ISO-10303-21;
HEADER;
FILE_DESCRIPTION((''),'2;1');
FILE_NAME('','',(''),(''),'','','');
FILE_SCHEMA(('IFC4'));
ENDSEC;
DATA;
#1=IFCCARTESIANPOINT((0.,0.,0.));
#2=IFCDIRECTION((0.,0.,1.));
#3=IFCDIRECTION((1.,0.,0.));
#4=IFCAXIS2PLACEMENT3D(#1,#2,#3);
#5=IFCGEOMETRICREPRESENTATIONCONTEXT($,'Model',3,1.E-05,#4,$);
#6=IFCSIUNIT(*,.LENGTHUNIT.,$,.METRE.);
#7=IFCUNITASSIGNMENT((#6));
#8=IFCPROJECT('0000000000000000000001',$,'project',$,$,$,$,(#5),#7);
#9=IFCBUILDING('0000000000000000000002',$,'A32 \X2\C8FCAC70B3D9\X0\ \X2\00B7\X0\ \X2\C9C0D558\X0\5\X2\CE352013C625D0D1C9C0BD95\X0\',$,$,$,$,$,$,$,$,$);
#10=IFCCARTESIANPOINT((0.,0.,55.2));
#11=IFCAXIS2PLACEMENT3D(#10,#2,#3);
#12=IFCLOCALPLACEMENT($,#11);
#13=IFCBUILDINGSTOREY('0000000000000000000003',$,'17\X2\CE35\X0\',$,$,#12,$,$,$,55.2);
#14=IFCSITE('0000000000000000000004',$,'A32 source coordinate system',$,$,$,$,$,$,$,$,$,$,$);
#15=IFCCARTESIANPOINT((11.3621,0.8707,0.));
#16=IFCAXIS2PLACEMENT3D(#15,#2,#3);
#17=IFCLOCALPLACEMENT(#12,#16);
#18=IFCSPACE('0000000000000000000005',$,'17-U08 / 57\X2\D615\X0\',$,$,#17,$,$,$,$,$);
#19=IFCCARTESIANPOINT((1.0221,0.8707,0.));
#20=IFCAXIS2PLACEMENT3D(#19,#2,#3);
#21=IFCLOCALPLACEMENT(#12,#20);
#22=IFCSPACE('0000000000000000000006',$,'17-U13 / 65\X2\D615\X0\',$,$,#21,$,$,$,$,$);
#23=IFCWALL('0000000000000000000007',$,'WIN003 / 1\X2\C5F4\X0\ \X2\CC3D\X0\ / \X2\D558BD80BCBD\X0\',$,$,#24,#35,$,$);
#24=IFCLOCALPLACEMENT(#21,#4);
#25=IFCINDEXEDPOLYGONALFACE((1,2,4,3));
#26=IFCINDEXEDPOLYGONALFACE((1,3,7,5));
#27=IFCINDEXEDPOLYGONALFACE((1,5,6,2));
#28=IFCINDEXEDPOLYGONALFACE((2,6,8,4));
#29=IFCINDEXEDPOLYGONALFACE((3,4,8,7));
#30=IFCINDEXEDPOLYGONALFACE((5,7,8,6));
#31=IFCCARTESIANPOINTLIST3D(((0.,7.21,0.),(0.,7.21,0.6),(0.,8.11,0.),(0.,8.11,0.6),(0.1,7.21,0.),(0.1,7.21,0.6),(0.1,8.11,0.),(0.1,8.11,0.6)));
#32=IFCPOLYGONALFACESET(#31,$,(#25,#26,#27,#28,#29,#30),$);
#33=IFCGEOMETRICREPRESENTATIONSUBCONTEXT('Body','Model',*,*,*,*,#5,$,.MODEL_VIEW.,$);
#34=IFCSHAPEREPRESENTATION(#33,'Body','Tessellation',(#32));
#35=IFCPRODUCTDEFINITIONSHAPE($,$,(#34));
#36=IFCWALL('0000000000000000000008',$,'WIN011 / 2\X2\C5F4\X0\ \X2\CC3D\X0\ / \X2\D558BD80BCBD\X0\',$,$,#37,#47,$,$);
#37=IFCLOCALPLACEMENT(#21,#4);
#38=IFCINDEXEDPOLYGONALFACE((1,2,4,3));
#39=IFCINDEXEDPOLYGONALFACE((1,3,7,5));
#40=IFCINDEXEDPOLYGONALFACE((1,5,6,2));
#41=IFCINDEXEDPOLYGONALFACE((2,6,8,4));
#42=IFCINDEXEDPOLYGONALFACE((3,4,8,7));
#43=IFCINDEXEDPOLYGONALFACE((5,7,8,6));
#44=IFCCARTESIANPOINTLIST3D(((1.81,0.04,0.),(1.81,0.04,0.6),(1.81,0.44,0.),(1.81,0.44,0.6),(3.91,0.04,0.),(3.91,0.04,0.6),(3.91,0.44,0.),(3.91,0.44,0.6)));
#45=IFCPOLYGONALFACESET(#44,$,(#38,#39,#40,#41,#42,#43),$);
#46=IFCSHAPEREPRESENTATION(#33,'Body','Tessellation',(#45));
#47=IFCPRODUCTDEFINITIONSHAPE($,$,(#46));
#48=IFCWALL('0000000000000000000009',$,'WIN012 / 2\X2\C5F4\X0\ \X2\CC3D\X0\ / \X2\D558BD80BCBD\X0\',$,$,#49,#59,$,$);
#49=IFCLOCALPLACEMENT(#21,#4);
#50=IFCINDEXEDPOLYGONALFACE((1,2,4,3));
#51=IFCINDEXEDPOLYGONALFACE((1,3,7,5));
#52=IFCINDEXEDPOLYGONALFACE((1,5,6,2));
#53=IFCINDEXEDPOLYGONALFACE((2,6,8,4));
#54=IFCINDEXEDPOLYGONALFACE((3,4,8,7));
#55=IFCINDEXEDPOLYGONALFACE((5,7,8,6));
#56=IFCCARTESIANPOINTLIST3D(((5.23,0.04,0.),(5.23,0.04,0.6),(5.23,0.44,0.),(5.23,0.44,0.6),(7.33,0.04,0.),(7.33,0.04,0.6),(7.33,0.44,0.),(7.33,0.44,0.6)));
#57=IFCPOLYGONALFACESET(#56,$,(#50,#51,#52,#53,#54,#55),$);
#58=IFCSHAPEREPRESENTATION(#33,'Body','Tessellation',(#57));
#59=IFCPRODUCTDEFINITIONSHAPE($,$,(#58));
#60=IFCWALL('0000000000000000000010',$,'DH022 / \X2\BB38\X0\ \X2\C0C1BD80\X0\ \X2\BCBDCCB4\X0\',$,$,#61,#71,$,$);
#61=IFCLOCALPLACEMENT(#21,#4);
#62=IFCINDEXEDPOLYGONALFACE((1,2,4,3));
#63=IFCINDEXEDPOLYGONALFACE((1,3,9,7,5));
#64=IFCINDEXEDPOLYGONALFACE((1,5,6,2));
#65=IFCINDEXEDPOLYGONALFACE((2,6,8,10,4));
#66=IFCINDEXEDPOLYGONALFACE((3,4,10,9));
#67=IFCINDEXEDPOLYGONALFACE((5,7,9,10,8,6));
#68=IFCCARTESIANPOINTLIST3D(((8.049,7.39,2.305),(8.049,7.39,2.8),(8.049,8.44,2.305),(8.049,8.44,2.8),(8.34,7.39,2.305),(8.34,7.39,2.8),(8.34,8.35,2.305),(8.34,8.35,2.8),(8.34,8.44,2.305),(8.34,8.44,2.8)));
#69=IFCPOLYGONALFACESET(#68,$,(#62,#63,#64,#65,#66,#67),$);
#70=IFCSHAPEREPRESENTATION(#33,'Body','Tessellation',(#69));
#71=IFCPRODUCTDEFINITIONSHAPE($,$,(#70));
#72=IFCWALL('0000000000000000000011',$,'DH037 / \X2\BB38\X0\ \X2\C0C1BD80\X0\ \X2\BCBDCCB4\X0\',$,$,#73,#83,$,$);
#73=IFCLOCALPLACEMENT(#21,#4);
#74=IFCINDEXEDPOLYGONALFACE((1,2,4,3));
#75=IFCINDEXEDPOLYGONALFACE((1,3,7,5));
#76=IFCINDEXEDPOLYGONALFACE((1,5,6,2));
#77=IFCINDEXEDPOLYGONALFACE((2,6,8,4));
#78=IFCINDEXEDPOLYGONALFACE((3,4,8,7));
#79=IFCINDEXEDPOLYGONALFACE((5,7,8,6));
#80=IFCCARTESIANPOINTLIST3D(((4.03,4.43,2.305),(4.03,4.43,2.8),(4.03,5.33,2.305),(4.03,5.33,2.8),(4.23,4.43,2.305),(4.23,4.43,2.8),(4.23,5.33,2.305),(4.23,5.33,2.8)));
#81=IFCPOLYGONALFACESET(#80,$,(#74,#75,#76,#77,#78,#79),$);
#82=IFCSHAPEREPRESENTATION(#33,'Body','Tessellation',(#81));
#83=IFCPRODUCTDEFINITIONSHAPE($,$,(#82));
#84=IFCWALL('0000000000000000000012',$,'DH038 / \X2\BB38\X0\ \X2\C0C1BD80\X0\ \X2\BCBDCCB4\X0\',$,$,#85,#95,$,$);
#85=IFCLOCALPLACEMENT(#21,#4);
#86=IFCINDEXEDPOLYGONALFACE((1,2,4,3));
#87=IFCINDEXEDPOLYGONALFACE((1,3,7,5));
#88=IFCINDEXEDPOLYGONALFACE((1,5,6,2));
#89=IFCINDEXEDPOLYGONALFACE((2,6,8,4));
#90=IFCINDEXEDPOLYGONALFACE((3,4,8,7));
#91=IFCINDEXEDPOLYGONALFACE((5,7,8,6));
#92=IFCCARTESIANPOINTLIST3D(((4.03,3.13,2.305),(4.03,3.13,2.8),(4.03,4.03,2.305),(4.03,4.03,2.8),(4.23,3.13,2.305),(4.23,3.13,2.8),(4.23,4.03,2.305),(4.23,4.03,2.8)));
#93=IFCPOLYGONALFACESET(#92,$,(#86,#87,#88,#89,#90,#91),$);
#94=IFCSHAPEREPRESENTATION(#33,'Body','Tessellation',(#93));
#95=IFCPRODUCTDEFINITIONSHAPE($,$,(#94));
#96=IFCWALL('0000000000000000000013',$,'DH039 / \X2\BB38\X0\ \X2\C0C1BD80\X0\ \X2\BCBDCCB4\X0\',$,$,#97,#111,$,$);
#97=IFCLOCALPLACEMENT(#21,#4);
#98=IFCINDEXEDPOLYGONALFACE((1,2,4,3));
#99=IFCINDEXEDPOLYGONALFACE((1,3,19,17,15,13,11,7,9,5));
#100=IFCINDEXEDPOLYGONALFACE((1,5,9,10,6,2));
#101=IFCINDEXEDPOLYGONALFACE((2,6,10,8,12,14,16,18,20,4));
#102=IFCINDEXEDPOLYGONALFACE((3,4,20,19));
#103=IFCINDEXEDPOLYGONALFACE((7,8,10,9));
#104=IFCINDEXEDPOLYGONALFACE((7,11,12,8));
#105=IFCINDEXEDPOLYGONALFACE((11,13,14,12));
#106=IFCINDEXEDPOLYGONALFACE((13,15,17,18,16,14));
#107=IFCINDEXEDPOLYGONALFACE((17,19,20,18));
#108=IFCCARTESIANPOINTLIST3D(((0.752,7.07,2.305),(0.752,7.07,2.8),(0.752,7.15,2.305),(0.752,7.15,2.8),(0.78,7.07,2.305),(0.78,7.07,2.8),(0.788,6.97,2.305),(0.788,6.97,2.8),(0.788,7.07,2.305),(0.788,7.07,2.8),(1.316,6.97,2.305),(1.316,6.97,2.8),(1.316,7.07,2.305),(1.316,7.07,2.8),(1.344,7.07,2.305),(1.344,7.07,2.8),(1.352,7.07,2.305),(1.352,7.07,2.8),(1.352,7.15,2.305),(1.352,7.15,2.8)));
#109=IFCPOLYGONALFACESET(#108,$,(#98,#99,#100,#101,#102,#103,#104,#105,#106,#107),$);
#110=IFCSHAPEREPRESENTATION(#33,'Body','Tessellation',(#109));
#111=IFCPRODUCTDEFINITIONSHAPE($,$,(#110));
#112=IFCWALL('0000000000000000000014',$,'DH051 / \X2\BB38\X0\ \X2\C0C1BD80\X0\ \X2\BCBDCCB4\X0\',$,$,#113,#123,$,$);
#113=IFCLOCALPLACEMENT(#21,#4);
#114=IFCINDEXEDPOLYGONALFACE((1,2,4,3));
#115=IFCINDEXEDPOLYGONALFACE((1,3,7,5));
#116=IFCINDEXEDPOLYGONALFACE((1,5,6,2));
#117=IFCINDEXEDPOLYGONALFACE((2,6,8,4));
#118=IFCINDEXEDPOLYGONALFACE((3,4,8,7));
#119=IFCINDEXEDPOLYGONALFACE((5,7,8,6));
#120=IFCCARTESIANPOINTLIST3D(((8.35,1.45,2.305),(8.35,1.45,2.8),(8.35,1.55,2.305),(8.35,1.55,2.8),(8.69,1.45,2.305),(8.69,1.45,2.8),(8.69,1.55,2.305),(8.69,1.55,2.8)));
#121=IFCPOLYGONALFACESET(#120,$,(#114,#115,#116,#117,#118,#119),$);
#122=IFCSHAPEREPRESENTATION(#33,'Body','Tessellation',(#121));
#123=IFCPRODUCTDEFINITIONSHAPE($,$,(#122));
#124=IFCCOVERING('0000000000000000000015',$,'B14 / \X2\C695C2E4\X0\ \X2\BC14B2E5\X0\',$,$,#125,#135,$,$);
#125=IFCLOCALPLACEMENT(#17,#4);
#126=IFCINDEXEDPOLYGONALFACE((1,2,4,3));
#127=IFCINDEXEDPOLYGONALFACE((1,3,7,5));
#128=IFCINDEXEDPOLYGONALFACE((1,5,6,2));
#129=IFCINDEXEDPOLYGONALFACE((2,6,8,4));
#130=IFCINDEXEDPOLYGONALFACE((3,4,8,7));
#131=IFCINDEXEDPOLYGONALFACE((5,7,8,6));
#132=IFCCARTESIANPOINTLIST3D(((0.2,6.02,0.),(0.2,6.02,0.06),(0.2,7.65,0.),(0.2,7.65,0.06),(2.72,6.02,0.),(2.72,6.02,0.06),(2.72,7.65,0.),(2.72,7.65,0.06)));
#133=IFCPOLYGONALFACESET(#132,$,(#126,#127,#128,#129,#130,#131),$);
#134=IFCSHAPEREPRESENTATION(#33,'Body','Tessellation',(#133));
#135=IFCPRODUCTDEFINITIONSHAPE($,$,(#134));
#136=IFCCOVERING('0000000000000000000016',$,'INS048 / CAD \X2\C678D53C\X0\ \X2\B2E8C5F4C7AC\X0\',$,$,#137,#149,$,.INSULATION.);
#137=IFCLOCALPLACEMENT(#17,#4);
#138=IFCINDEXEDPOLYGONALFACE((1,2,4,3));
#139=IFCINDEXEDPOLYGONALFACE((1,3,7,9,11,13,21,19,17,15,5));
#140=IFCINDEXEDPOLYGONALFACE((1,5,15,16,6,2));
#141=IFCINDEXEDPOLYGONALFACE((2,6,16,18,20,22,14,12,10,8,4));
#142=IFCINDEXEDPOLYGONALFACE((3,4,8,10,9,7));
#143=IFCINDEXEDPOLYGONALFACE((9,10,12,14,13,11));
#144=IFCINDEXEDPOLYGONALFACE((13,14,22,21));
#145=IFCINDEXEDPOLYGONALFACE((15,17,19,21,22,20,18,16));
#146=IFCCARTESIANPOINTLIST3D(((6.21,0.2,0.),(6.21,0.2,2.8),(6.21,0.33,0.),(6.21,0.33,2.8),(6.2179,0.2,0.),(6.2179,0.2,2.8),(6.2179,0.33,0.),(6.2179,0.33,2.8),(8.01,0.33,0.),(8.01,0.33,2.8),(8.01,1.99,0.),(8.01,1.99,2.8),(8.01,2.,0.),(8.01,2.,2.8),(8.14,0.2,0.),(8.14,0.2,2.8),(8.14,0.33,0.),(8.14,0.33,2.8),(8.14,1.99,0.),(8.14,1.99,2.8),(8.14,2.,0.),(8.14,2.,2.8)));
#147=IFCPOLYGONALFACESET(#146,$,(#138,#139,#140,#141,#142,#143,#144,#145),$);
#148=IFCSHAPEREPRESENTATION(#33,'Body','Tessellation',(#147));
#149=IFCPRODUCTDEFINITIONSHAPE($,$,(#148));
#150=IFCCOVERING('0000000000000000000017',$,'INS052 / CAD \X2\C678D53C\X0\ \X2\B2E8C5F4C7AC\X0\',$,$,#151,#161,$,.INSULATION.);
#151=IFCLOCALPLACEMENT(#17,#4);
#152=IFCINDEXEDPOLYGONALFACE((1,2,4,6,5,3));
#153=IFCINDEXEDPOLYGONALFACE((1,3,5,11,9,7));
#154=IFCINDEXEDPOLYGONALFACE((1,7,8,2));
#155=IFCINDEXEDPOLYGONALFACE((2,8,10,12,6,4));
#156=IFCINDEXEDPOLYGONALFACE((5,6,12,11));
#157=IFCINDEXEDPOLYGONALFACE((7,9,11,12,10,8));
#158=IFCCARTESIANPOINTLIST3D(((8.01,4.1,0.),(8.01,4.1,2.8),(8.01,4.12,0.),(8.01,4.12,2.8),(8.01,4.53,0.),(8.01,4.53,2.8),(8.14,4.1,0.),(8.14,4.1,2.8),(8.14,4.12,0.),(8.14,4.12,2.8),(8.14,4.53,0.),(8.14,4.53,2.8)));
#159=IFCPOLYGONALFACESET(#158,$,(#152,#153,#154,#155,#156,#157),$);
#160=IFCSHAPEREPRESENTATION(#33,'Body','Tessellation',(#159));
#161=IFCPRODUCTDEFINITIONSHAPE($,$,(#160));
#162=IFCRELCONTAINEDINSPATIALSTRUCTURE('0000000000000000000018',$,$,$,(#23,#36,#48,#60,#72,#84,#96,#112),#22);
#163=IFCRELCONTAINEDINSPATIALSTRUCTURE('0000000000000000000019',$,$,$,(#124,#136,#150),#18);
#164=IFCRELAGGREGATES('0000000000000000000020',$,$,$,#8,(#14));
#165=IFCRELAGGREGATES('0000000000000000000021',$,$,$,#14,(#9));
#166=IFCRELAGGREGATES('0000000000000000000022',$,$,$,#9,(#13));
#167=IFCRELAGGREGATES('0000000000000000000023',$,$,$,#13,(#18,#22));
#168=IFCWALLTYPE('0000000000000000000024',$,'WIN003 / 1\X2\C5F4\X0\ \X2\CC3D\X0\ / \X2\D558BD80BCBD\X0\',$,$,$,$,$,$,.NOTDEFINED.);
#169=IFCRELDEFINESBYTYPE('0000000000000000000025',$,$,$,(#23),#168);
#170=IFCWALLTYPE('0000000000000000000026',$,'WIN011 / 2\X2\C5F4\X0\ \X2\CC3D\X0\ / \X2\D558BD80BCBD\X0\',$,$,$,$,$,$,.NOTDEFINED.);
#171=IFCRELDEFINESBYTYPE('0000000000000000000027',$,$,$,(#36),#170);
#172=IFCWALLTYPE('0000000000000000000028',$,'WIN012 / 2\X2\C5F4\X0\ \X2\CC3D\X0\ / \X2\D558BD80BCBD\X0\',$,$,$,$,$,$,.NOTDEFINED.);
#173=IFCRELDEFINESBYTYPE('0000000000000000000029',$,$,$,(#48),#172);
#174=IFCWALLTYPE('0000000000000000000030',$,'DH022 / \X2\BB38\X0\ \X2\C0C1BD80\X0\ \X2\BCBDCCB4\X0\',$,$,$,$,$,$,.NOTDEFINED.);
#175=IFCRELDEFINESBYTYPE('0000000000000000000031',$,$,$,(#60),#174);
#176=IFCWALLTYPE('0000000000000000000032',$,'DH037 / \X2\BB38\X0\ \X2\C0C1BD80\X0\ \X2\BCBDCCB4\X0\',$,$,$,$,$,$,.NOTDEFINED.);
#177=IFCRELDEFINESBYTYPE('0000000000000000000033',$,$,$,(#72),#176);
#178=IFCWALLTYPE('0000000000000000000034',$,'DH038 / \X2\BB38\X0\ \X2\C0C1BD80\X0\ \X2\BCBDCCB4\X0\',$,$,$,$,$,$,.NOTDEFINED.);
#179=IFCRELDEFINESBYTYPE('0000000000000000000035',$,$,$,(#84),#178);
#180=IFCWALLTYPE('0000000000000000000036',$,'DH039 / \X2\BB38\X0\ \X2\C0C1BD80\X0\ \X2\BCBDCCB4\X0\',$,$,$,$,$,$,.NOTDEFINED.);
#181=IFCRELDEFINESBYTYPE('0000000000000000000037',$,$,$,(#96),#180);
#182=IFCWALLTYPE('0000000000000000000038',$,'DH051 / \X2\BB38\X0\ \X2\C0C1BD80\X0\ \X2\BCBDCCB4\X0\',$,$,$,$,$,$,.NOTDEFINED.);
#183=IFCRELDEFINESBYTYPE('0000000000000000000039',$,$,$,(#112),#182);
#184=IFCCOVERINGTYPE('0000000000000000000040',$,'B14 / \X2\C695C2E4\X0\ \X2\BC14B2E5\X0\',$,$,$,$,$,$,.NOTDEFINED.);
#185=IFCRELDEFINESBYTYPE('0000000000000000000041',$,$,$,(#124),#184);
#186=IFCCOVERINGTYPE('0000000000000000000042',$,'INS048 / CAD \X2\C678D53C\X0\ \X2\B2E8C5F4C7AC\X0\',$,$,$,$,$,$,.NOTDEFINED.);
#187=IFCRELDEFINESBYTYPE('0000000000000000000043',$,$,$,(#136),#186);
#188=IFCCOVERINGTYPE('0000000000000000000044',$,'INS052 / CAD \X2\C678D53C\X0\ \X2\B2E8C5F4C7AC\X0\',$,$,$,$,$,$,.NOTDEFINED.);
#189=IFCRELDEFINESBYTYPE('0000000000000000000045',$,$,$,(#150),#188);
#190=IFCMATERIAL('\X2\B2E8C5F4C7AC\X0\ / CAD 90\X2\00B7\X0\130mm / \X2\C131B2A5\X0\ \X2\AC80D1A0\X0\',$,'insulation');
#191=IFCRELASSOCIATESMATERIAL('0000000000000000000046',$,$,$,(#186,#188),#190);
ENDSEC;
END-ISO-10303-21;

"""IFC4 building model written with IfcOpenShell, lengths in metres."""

from ifc_helpers import new_model, si_unit, frame, origin, origin_with_axes, place, context, subcontext, project, spatial, polyline, outline, extrude, source, transform, mapped, material, type_object, type_shapes, element, save


model = new_model("IFC4")

# Units and contexts
model_context = context("Model", 3, precision=1e-05, world=origin_with_axes())
body_context = subcontext(model_context, "Body", "Model", "MODEL_VIEW")
ifc_project = project(units=[si_unit("LENGTHUNIT", "METRE")], contexts=[model_context])

# Site, building, storey, space
site = spatial("IfcSite", under=ifc_project, Name="A32 source coordinate system")
building = spatial("IfcBuilding", under=site, Name="A32 주거동 · 지하5층–옥탑지붕")
storey_placement = place(None, frame((0.0, 0.0, 55.2), z_axis=(0.0, 0.0, 1.0), x_axis=(1.0, 0.0, 0.0)))
storey = spatial("IfcBuildingStorey", under=building, at=storey_placement, Name="17층", Elevation=55.2)
space_1_placement = place(storey_placement, frame((11.3621, 0.8707, 0.0), z_axis=(0.0, 0.0, 1.0), x_axis=(1.0, 0.0, 0.0)))
space_1 = spatial("IfcSpace", under=storey, at=space_1_placement, Name="17-U08 / 57형")

# Shared definitions
space_2_placement = place(storey_placement, frame((1.0221, 0.8707, 0.0), z_axis=(0.0, 0.0, 1.0), x_axis=(1.0, 0.0, 0.0)))
space_2 = spatial("IfcSpace", under=storey, at=space_2_placement, Name="17-U13 / 65형")

# Walls
wall_type_1 = type_object("IfcWallType", Name="WIN003 / 1열 창 / 하부벽", PredefinedType="NOTDEFINED")
shared_shape_1 = source(origin(), body_context, "Body", "SweptSolid", [
    extrude(outline(polyline([(0.0, 8.11), (0.1, 8.11), (0.1, 7.21), (0.0, 7.21), (0.0, 8.11)])), origin(), (0.0, 0.0, 1.0), 0.6),
])
type_shapes(wall_type_1, [shared_shape_1])
wall_1_placement = place(space_2_placement, origin_with_axes())
element("IfcWall", 1, at=wall_1_placement, inside=space_2, type_object=wall_type_1, Name="WIN003 / 1열 창 / 하부벽", context=body_context, shape_type="MappedRepresentation", body=[
    mapped(shared_shape_1, transform((0.0, 0.0, 0.0), scale=1.0)),
])
wall_type_2 = type_object("IfcWallType", Name="WIN011 / 2열 창 / 하부벽", PredefinedType="NOTDEFINED")
shared_shape_2 = source(origin(), body_context, "Body", "SweptSolid", [
    extrude(outline(polyline([(1.81, 0.44), (3.91, 0.44), (3.91, 0.04), (1.81, 0.04), (1.81, 0.44)])), origin(), (0.0, 0.0, 1.0), 0.6),
])
type_shapes(wall_type_2, [shared_shape_2])
wall_2_placement = place(space_2_placement, origin_with_axes())
element("IfcWall", 2, at=wall_2_placement, inside=space_2, type_object=wall_type_2, Name="WIN011 / 2열 창 / 하부벽", context=body_context, shape_type="MappedRepresentation", body=[
    mapped(shared_shape_2, transform((0.0, 0.0, 0.0), scale=1.0)),
])
wall_type_3 = type_object("IfcWallType", Name="WIN012 / 2열 창 / 하부벽", PredefinedType="NOTDEFINED")
shared_shape_3 = source(origin(), body_context, "Body", "SweptSolid", [
    extrude(outline(polyline([(5.23, 0.44), (7.33, 0.44), (7.33, 0.04), (5.23, 0.04), (5.23, 0.44)])), origin(), (0.0, 0.0, 1.0), 0.6),
])
type_shapes(wall_type_3, [shared_shape_3])
wall_3_placement = place(space_2_placement, origin_with_axes())
element("IfcWall", 3, at=wall_3_placement, inside=space_2, type_object=wall_type_3, Name="WIN012 / 2열 창 / 하부벽", context=body_context, shape_type="MappedRepresentation", body=[
    mapped(shared_shape_3, transform((0.0, 0.0, 0.0), scale=1.0)),
])
wall_type_4 = type_object("IfcWallType", Name="DH022 / 문 상부 벽체", PredefinedType="NOTDEFINED")
shared_shape_4 = source(origin(), body_context, "Body", "SweptSolid", [
    extrude(outline(polyline([(8.049, 7.39), (8.049, 8.44), (8.34, 8.44), (8.34, 8.35), (8.34, 8.35), (8.34, 7.39), (8.049, 7.39)])), frame((0.0, 0.0, 2.305)), (0.0, 0.0, 1.0), 0.495),
])
type_shapes(wall_type_4, [shared_shape_4])
wall_4_placement = place(space_2_placement, origin_with_axes())
element("IfcWall", 4, at=wall_4_placement, inside=space_2, type_object=wall_type_4, Name="DH022 / 문 상부 벽체", context=body_context, shape_type="MappedRepresentation", body=[
    mapped(shared_shape_4, transform((0.0, 0.0, 0.0), scale=1.0)),
])
wall_type_5 = type_object("IfcWallType", Name="DH037 / 문 상부 벽체", PredefinedType="NOTDEFINED")
shared_shape_5 = source(origin(), body_context, "Body", "SweptSolid", [
    extrude(outline(polyline([(4.23, 5.33), (4.23, 4.43), (4.03, 4.43), (4.03, 5.33), (4.23, 5.33)])), frame((0.0, 0.0, 2.305)), (0.0, 0.0, 1.0), 0.495),
])
type_shapes(wall_type_5, [shared_shape_5])
wall_5_placement = place(space_2_placement, origin_with_axes())
element("IfcWall", 5, at=wall_5_placement, inside=space_2, type_object=wall_type_5, Name="DH037 / 문 상부 벽체", context=body_context, shape_type="MappedRepresentation", body=[
    mapped(shared_shape_5, transform((0.0, 0.0, 0.0), scale=1.0)),
])
wall_type_6 = type_object("IfcWallType", Name="DH038 / 문 상부 벽체", PredefinedType="NOTDEFINED")
shared_shape_6 = source(origin(), body_context, "Body", "SweptSolid", [
    extrude(outline(polyline([(4.23, 4.03), (4.23, 3.13), (4.03, 3.13), (4.03, 4.03), (4.23, 4.03)])), frame((0.0, 0.0, 2.305)), (0.0, 0.0, 1.0), 0.495),
])
type_shapes(wall_type_6, [shared_shape_6])
wall_6_placement = place(space_2_placement, origin_with_axes())
element("IfcWall", 6, at=wall_6_placement, inside=space_2, type_object=wall_type_6, Name="DH038 / 문 상부 벽체", context=body_context, shape_type="MappedRepresentation", body=[
    mapped(shared_shape_6, transform((0.0, 0.0, 0.0), scale=1.0)),
])
wall_type_7 = type_object("IfcWallType", Name="DH039 / 문 상부 벽체", PredefinedType="NOTDEFINED")
shared_shape_7 = source(origin(), body_context, "Body", "SweptSolid", [
    extrude(outline(polyline([(1.316, 7.07), (1.316, 6.97), (0.788, 6.97), (0.788, 7.07), (0.78, 7.07), (0.752, 7.07), (0.752, 7.15), (1.352, 7.15), (1.352, 7.07), (1.344, 7.07), (1.316, 7.07)])), frame((0.0, 0.0, 2.305)), (0.0, 0.0, 1.0), 0.495),
])
type_shapes(wall_type_7, [shared_shape_7])
wall_7_placement = place(space_2_placement, origin_with_axes())
element("IfcWall", 7, at=wall_7_placement, inside=space_2, type_object=wall_type_7, Name="DH039 / 문 상부 벽체", context=body_context, shape_type="MappedRepresentation", body=[
    mapped(shared_shape_7, transform((0.0, 0.0, 0.0), scale=1.0)),
])
wall_type_8 = type_object("IfcWallType", Name="DH051 / 문 상부 벽체", PredefinedType="NOTDEFINED")
shared_shape_8 = source(origin(), body_context, "Body", "SweptSolid", [
    extrude(outline(polyline([(8.69, 1.55), (8.69, 1.45), (8.35, 1.45), (8.35, 1.55), (8.69, 1.55)])), frame((0.0, 0.0, 2.305)), (0.0, 0.0, 1.0), 0.495),
])
type_shapes(wall_type_8, [shared_shape_8])
wall_8_placement = place(space_2_placement, origin_with_axes())
element("IfcWall", 8, at=wall_8_placement, inside=space_2, type_object=wall_type_8, Name="DH051 / 문 상부 벽체", context=body_context, shape_type="MappedRepresentation", body=[
    mapped(shared_shape_8, transform((0.0, 0.0, 0.0), scale=1.0)),
])

# Coverings
covering_type_1 = type_object("IfcCoveringType", Name="B14 / 욕실 바닥", PredefinedType="NOTDEFINED")
shared_shape_9 = source(origin(), body_context, "Body", "SweptSolid", [
    extrude(outline(polyline([(0.2, 7.65), (2.72, 7.65), (2.72, 6.02), (0.2, 6.02), (0.2, 7.65)])), origin(), (0.0, 0.0, 1.0), 0.06),
])
type_shapes(covering_type_1, [shared_shape_9])
covering_1_placement = place(space_1_placement, origin_with_axes())
element("IfcCovering", 9, at=covering_1_placement, inside=space_1, type_object=covering_type_1, Name="B14 / 욕실 바닥", context=body_context, shape_type="MappedRepresentation", body=[
    mapped(shared_shape_9, transform((0.0, 0.0, 0.0), scale=1.0)),
])
ifc_material = material(Name="단열재 / CAD 90·130mm / 성능 검토", Category="insulation")
covering_type_2 = type_object("IfcCoveringType", Name="INS048 / CAD 외피 단열재", PredefinedType="NOTDEFINED", material=ifc_material)
shared_shape_10 = source(origin(), body_context, "Body", "SweptSolid", [
    extrude(outline(polyline([(8.01, 1.99), (8.01, 2.0), (8.14, 2.0), (8.14, 1.99), (8.14, 0.33), (8.14, 0.2), (6.2179, 0.2), (6.21, 0.2), (6.21, 0.33), (6.2179, 0.33), (8.01, 0.33), (8.01, 1.99)])), origin(), (0.0, 0.0, 1.0), 2.8),
])
type_shapes(covering_type_2, [shared_shape_10])
covering_2_placement = place(space_1_placement, origin_with_axes())
element("IfcCovering", 10, at=covering_2_placement, inside=space_1, type_object=covering_type_2, Name="INS048 / CAD 외피 단열재", PredefinedType="INSULATION", context=body_context, shape_type="MappedRepresentation", body=[
    mapped(shared_shape_10, transform((0.0, 0.0, 0.0), scale=1.0)),
])
covering_type_3 = type_object("IfcCoveringType", Name="INS052 / CAD 외피 단열재", PredefinedType="NOTDEFINED", material=ifc_material)
shared_shape_11 = source(origin(), body_context, "Body", "SweptSolid", [
    extrude(outline(polyline([(8.14, 4.1), (8.01, 4.1), (8.01, 4.12), (8.01, 4.53), (8.14, 4.53), (8.14, 4.12), (8.14, 4.1)])), origin(), (0.0, 0.0, 1.0), 2.8),
])
type_shapes(covering_type_3, [shared_shape_11])
covering_3_placement = place(space_1_placement, origin_with_axes())
element("IfcCovering", 11, at=covering_3_placement, inside=space_1, type_object=covering_type_3, Name="INS052 / CAD 외피 단열재", PredefinedType="INSULATION", context=body_context, shape_type="MappedRepresentation", body=[
    mapped(shared_shape_11, transform((0.0, 0.0, 0.0), scale=1.0)),
])

save(model, "model.ifc")
